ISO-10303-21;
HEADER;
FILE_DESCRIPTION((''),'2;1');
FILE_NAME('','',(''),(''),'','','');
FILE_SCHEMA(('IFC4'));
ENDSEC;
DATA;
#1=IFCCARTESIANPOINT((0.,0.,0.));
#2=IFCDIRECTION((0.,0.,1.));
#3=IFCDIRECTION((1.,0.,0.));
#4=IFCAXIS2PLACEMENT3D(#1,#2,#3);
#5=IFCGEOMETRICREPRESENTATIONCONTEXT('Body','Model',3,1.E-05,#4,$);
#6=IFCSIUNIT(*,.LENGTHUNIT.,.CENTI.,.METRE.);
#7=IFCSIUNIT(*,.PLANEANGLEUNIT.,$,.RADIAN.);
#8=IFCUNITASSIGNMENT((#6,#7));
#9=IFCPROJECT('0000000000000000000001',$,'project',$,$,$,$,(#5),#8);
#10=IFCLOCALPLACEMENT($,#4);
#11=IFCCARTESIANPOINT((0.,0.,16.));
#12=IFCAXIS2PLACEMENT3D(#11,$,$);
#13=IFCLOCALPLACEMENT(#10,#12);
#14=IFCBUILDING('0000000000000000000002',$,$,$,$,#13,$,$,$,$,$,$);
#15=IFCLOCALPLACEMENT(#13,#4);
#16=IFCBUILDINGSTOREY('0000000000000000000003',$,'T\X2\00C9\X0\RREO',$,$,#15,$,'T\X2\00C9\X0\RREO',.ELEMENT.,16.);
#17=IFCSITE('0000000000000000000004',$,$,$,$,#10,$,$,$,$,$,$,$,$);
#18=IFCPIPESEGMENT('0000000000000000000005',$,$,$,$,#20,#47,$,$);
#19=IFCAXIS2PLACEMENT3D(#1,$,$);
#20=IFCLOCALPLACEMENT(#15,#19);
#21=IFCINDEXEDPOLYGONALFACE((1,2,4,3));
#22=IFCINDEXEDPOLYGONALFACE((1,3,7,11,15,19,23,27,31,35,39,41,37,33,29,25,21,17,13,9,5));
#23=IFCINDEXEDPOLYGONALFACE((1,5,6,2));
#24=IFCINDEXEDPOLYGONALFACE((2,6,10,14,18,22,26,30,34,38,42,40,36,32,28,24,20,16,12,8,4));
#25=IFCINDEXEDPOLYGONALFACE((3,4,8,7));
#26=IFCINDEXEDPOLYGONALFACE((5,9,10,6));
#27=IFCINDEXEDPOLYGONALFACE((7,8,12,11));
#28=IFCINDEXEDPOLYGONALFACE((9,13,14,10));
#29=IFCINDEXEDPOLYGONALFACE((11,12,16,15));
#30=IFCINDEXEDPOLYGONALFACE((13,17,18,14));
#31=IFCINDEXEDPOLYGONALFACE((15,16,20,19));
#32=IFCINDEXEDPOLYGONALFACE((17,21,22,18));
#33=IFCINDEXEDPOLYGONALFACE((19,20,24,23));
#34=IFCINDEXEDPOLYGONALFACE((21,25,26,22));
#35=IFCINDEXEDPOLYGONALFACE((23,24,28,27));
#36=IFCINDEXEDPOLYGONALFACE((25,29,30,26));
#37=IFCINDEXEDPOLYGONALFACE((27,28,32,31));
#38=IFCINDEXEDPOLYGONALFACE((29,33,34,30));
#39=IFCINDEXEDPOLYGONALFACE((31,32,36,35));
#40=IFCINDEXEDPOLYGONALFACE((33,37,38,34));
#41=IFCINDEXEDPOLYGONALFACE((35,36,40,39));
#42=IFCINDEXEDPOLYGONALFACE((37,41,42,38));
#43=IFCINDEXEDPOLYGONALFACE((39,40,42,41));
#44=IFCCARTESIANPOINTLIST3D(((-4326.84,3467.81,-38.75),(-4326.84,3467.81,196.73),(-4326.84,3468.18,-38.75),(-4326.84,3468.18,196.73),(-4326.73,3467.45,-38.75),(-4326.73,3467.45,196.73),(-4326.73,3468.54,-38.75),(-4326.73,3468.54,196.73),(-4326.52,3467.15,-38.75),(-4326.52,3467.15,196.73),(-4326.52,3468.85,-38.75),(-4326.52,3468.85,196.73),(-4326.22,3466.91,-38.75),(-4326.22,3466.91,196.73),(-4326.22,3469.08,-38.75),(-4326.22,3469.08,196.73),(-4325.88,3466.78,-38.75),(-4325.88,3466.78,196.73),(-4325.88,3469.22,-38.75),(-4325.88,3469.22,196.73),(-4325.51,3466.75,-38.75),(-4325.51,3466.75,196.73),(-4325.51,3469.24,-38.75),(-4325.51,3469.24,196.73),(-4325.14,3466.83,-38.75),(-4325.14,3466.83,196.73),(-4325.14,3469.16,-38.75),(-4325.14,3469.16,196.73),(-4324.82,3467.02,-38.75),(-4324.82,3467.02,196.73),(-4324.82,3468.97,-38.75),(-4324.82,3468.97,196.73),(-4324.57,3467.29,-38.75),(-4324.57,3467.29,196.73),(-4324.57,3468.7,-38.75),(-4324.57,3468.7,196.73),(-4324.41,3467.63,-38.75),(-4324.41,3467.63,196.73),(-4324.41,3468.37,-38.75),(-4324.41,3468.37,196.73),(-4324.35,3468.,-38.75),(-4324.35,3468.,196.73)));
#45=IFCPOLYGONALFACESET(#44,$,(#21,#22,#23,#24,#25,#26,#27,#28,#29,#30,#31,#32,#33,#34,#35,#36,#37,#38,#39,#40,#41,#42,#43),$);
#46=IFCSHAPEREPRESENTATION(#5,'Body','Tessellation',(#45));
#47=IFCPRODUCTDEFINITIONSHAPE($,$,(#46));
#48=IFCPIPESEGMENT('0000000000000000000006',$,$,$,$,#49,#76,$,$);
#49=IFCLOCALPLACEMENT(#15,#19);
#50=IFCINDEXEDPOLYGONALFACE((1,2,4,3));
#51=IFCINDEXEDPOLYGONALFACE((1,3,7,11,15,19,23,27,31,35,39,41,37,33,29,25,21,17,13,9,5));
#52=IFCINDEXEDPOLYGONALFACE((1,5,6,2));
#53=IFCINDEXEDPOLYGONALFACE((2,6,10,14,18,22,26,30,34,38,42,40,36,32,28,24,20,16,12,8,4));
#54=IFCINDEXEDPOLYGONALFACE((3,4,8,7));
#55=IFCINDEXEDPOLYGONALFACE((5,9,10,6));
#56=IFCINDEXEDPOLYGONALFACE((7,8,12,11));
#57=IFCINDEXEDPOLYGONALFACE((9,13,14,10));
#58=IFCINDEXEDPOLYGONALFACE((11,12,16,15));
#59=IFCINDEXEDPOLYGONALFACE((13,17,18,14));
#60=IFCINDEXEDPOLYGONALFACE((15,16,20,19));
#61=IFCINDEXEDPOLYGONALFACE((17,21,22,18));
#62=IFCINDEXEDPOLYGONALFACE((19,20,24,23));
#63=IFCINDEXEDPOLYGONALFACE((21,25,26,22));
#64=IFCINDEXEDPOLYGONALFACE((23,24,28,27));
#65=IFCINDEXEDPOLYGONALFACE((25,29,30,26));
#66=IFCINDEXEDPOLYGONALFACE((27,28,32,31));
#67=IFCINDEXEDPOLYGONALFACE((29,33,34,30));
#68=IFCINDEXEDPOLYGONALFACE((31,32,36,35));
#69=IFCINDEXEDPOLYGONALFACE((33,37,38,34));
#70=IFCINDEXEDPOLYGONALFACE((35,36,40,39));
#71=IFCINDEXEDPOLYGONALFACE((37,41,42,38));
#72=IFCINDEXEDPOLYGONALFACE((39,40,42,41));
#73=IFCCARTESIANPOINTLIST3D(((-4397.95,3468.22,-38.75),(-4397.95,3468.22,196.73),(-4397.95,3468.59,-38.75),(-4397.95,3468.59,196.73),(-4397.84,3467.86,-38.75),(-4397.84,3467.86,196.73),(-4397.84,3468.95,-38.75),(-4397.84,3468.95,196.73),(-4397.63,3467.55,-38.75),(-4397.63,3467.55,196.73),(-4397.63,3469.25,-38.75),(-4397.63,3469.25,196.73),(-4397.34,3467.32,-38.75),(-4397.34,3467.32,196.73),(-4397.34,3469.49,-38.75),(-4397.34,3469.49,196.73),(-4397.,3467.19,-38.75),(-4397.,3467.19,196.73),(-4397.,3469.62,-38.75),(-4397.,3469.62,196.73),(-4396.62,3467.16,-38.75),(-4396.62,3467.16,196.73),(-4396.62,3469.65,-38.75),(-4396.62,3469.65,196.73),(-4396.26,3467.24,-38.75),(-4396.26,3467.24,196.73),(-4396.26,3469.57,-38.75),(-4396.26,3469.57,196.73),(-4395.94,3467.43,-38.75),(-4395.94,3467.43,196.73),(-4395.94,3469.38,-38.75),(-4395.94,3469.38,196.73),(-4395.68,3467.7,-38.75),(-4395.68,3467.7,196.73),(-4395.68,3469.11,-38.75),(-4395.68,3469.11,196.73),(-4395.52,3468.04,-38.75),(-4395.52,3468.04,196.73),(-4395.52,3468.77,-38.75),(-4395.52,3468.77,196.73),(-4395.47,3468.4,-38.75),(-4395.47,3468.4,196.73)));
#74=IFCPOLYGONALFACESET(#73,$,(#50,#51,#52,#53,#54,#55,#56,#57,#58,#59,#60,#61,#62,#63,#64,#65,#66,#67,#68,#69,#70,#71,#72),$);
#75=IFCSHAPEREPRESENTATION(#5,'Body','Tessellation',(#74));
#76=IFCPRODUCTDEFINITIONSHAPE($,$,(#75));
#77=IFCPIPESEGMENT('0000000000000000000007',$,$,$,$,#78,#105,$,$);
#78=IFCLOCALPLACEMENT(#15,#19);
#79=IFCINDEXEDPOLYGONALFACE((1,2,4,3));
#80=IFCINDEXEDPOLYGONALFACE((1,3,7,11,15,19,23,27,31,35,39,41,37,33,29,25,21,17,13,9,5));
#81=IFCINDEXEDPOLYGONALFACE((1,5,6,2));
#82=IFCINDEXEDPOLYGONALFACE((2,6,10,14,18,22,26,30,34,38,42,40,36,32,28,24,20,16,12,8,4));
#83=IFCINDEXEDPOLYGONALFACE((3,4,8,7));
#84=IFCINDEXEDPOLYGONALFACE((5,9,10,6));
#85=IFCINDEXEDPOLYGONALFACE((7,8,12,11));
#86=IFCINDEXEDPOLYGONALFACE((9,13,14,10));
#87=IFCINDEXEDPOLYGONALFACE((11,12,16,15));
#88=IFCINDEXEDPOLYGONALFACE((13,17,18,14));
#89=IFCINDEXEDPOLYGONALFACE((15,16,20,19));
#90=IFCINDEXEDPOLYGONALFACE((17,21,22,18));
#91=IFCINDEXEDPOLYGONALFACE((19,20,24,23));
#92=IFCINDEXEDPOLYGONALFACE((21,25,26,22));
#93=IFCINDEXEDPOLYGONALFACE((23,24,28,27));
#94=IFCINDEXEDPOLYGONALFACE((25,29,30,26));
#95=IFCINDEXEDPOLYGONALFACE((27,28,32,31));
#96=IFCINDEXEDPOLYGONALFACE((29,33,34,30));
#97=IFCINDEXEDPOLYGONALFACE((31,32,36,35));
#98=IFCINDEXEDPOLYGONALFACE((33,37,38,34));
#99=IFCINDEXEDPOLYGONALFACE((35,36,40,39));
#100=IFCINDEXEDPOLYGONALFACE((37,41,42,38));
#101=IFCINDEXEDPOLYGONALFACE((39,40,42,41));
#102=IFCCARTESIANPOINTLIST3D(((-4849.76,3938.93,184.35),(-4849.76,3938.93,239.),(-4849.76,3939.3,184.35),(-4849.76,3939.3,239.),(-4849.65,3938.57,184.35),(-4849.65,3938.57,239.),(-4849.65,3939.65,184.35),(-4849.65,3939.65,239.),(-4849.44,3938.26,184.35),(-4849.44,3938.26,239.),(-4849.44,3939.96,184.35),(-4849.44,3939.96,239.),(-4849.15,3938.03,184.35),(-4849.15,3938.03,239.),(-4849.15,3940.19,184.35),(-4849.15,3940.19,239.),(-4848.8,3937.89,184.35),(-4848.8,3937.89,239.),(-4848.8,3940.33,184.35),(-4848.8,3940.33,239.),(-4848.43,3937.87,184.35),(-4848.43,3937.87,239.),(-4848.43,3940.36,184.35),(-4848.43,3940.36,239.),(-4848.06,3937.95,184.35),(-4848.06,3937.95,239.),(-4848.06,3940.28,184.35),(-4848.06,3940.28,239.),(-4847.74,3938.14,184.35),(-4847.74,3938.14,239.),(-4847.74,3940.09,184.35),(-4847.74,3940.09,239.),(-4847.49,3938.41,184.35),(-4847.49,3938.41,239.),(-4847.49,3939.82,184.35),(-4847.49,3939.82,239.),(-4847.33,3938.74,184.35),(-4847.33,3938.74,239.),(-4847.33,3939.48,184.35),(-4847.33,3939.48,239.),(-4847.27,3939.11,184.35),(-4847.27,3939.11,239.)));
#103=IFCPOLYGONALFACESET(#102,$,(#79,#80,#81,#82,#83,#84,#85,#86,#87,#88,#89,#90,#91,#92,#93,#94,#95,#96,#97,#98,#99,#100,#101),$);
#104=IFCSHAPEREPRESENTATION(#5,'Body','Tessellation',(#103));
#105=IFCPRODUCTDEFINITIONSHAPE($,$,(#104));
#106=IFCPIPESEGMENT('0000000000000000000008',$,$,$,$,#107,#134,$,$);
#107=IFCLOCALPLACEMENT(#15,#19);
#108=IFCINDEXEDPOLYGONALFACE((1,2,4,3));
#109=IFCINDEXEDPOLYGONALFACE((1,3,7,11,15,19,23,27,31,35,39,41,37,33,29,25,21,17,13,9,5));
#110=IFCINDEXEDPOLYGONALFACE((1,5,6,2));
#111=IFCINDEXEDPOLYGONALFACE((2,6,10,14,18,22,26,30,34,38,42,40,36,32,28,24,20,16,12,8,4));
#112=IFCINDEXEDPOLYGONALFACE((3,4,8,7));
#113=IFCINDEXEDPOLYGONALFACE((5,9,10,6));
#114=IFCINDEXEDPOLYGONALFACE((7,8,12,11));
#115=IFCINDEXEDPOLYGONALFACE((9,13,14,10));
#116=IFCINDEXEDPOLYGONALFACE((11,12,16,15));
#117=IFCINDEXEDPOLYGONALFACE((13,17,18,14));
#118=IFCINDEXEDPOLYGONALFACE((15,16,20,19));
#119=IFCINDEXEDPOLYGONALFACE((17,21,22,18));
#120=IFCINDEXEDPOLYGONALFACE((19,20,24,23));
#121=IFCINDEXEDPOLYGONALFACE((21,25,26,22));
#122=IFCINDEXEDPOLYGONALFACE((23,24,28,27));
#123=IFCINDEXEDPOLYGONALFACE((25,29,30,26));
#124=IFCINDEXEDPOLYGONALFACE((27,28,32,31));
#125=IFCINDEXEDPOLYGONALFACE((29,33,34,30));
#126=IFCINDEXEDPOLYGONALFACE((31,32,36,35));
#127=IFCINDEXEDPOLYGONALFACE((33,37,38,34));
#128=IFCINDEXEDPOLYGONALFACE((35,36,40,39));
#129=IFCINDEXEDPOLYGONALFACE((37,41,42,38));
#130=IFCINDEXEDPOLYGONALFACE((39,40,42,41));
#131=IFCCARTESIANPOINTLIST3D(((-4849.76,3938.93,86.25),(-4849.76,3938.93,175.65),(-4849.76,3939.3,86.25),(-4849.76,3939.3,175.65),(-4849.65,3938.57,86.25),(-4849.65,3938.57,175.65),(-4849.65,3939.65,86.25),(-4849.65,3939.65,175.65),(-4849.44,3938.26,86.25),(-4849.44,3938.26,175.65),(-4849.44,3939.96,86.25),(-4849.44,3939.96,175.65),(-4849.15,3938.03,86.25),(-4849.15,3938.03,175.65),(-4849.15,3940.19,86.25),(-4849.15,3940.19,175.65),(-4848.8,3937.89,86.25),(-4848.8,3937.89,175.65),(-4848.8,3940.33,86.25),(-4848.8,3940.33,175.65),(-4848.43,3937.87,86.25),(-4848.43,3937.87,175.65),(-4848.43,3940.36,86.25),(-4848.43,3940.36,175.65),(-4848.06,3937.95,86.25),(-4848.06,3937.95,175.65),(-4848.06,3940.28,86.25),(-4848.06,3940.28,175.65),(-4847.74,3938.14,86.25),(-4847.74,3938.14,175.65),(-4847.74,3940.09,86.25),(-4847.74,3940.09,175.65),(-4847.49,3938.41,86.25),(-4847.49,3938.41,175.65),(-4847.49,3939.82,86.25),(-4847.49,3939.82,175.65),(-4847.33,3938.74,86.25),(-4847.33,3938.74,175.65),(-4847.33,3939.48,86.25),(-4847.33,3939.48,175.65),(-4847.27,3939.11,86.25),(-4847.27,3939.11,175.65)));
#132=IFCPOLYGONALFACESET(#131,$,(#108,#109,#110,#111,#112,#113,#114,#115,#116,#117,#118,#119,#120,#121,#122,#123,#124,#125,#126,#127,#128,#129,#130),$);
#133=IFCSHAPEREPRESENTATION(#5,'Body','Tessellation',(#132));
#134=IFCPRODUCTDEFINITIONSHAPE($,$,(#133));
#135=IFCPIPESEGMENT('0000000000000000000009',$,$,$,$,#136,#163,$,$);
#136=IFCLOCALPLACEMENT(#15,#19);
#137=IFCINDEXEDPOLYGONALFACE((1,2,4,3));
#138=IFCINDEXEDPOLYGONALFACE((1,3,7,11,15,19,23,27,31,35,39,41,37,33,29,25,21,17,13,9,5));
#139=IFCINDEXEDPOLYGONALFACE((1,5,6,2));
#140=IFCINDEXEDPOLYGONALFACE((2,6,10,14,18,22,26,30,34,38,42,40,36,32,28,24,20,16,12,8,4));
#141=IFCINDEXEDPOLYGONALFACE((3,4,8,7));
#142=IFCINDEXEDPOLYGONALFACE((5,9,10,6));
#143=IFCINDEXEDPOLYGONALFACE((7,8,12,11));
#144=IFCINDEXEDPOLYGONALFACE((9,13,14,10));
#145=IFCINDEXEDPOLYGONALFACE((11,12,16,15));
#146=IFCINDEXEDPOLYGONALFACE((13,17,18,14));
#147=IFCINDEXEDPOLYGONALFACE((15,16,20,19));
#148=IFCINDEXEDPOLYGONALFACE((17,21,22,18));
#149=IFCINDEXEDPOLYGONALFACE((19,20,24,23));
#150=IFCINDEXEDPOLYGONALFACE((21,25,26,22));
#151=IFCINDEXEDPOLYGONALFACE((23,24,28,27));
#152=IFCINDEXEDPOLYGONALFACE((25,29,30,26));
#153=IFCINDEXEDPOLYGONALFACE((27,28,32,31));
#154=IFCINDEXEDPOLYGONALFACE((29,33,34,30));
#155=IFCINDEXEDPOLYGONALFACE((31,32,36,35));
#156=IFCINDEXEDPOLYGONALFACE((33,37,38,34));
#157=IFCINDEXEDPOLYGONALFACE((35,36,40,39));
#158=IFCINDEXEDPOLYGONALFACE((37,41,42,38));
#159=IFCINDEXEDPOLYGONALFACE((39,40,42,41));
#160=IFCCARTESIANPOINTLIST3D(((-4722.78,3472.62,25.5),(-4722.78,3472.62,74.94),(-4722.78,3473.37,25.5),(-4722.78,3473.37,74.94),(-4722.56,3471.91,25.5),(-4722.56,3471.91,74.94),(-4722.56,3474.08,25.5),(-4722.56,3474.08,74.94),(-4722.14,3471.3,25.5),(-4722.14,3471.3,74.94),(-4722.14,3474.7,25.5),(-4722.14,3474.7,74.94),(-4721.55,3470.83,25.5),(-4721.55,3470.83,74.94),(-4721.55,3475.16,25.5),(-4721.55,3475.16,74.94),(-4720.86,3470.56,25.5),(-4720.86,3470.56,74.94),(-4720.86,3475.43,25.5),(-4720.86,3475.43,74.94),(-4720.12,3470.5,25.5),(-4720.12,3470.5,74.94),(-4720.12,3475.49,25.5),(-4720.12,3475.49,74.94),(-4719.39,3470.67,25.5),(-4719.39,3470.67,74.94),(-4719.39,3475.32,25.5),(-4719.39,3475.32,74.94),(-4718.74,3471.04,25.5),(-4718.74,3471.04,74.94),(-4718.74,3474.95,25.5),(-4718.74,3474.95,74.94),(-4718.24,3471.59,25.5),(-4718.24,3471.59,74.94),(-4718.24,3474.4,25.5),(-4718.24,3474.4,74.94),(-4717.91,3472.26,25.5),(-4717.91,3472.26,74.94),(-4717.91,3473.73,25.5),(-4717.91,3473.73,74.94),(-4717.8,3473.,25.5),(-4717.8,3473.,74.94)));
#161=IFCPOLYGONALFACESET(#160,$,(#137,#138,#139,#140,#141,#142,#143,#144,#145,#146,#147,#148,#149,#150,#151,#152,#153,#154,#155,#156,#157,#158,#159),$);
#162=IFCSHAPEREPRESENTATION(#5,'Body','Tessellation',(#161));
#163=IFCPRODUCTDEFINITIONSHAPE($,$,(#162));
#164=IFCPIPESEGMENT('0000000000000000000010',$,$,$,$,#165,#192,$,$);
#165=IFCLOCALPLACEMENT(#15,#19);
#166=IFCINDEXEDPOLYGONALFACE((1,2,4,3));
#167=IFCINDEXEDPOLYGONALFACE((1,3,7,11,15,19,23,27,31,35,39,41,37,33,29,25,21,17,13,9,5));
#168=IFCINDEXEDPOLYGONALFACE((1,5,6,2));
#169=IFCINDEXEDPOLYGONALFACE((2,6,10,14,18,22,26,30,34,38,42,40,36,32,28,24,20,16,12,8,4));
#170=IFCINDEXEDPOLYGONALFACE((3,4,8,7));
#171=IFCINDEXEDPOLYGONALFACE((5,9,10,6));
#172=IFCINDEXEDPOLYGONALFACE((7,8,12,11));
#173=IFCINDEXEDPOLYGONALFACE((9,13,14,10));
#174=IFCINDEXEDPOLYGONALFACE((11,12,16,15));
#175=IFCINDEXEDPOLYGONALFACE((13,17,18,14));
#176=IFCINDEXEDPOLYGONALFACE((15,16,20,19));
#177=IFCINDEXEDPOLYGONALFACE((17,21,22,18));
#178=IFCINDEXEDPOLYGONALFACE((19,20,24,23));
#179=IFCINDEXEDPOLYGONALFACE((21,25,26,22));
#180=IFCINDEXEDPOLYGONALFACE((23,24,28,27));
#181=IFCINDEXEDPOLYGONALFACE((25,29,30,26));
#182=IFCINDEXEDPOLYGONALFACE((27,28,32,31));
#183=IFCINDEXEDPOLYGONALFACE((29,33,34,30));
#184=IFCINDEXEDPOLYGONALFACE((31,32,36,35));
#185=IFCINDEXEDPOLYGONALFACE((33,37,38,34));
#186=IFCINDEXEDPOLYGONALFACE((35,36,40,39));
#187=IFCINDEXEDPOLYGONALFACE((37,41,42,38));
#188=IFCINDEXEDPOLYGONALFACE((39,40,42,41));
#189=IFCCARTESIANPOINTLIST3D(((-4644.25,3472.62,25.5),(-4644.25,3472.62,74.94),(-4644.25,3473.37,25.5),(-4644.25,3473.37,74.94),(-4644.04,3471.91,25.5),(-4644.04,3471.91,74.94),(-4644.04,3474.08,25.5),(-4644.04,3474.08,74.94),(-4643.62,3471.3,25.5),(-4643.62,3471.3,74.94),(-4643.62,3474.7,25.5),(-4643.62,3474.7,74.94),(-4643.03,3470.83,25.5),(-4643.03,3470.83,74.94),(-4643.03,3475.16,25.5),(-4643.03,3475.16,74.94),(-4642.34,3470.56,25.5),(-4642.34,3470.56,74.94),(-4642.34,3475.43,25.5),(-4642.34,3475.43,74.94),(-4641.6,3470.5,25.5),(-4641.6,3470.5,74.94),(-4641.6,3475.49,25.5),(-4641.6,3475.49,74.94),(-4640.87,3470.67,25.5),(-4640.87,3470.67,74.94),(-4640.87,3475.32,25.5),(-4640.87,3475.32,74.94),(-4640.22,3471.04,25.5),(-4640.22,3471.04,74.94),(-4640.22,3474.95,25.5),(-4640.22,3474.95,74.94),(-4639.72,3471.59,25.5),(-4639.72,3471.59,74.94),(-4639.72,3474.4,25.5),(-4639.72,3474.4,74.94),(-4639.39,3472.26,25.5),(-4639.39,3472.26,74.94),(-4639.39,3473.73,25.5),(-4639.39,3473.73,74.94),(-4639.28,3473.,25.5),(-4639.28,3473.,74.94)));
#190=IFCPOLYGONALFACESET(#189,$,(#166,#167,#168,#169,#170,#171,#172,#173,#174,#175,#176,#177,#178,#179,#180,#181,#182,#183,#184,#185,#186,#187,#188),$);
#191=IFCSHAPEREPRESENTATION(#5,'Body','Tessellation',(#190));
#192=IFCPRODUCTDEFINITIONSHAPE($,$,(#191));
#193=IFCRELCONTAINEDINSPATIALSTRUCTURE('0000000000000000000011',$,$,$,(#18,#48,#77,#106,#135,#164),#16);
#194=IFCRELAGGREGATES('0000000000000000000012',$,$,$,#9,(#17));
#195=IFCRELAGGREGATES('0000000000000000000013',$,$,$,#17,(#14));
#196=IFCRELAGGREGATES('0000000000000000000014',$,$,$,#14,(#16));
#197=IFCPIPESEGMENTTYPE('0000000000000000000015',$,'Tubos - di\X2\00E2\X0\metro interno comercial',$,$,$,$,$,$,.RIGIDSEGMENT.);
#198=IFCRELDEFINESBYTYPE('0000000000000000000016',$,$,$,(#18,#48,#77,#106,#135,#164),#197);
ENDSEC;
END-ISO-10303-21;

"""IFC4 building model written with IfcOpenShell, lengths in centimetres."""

from ifc_helpers import new_model, si_unit, frame, origin_with_axes, origin_2d_with_axis, place, context, project, spatial, circle, extrude, type_object, element, save


model = new_model("IFC4")

# Units and contexts
model_context = context("Model", 3, precision=1e-05, world=origin_with_axes(), identifier="Body")
ifc_project = project(units=[si_unit("LENGTHUNIT", "METRE", prefix="CENTI"), si_unit("PLANEANGLEUNIT", "RADIAN")], contexts=[model_context])

# Site, building, storey
site_placement = place(None, origin_with_axes())
site = spatial("IfcSite", under=ifc_project, at=site_placement)
building_placement = place(site_placement, frame((0.0, 0.0, 16.0)))
building = spatial("IfcBuilding", under=site, at=building_placement)
storey_placement = place(building_placement, origin_with_axes())
storey = spatial("IfcBuildingStorey", under=building, at=storey_placement, Name="TÉRREO", LongName="TÉRREO", CompositionType="ELEMENT", Elevation=16.0)

# Pipe segments
pipe_segment_type = type_object("IfcPipeSegmentType", Name="Tubos - diâmetro interno comercial", PredefinedType="RIGIDSEGMENT")
pipe_segment_1_placement = place(storey_placement, frame((-4325.6, 3468.0, 196.73), z_axis=(0.0, 0.0, 1.0), x_axis=(1.0, 0.0, 0.0)))
element("IfcPipeSegment", 1, at=pipe_segment_1_placement, inside=storey, type_object=pipe_segment_type, context=model_context, shape_type="SolidModel", body=[
    extrude(circle(Radius=1.25, at=origin_2d_with_axis()), frame((0.0, 0.0, -235.48), z_axis=(0.0, 0.0, 1.0), x_axis=(1.0, 0.0, 0.0)), (0.0, 0.0, 1.0), 235.48),
])
pipe_segment_2_placement = place(storey_placement, frame((-4396.72, 3468.4, 196.73), z_axis=(0.0, 0.0, 1.0), x_axis=(1.0, 0.0, 0.0)))
element("IfcPipeSegment", 2, at=pipe_segment_2_placement, inside=storey, type_object=pipe_segment_type, context=model_context, shape_type="SolidModel", body=[
    extrude(circle(Radius=1.25, at=origin_2d_with_axis()), frame((0.0, 0.0, -235.48), z_axis=(0.0, 0.0, 1.0), x_axis=(1.0, 0.0, 0.0)), (0.0, 0.0, 1.0), 235.48),
])
pipe_segment_3_placement = place(storey_placement, frame((-4848.52, 3939.11, 239.0), z_axis=(0.0, 0.0, 1.0), x_axis=(1.0, 0.0, 0.0)))
element("IfcPipeSegment", 3, at=pipe_segment_3_placement, inside=storey, type_object=pipe_segment_type, context=model_context, shape_type="SolidModel", body=[
    extrude(circle(Radius=1.25, at=origin_2d_with_axis()), frame((0.0, 0.0, 0.0), z_axis=(0.0, 0.0, -1.0), x_axis=(1.0, 0.0, 0.0)), (0.0, 0.0, 1.0), 54.65),
])
pipe_segment_4_placement = place(storey_placement, frame((-4848.52, 3939.11, 175.65), z_axis=(0.0, 0.0, 1.0), x_axis=(1.0, 0.0, 0.0)))
element("IfcPipeSegment", 4, at=pipe_segment_4_placement, inside=storey, type_object=pipe_segment_type, context=model_context, shape_type="SolidModel", body=[
    extrude(circle(Radius=1.25, at=origin_2d_with_axis()), frame((0.0, 0.0, 0.0), z_axis=(0.0, 0.0, -1.0), x_axis=(1.0, 0.0, 0.0)), (0.0, 0.0, 1.0), 89.4),
])
for number, where, z_axis, x_axis in (
    (5, (-4720.3, 3473.0, 74.94), (0.0, 0.0, 1.0), (1.0, 0.0, 0.0)),
    (6, (-4641.78, 3473.0, 74.94), (0.0, 0.0, 1.0), (1.0, 0.0, 0.0)),
):
    element("IfcPipeSegment", number, at=place(storey_placement, frame(where, z_axis=z_axis, x_axis=x_axis)), inside=storey, type_object=pipe_segment_type, context=model_context, shape_type="SolidModel", body=[
        extrude(circle(Radius=2.5, at=origin_2d_with_axis()), frame((0.0, 0.0, 0.0), z_axis=(0.0, 0.0, -1.0), x_axis=(1.0, 0.0, 0.0)), (0.0, 0.0, 1.0), 49.44),
    ])

save(model, "model.ifc")
